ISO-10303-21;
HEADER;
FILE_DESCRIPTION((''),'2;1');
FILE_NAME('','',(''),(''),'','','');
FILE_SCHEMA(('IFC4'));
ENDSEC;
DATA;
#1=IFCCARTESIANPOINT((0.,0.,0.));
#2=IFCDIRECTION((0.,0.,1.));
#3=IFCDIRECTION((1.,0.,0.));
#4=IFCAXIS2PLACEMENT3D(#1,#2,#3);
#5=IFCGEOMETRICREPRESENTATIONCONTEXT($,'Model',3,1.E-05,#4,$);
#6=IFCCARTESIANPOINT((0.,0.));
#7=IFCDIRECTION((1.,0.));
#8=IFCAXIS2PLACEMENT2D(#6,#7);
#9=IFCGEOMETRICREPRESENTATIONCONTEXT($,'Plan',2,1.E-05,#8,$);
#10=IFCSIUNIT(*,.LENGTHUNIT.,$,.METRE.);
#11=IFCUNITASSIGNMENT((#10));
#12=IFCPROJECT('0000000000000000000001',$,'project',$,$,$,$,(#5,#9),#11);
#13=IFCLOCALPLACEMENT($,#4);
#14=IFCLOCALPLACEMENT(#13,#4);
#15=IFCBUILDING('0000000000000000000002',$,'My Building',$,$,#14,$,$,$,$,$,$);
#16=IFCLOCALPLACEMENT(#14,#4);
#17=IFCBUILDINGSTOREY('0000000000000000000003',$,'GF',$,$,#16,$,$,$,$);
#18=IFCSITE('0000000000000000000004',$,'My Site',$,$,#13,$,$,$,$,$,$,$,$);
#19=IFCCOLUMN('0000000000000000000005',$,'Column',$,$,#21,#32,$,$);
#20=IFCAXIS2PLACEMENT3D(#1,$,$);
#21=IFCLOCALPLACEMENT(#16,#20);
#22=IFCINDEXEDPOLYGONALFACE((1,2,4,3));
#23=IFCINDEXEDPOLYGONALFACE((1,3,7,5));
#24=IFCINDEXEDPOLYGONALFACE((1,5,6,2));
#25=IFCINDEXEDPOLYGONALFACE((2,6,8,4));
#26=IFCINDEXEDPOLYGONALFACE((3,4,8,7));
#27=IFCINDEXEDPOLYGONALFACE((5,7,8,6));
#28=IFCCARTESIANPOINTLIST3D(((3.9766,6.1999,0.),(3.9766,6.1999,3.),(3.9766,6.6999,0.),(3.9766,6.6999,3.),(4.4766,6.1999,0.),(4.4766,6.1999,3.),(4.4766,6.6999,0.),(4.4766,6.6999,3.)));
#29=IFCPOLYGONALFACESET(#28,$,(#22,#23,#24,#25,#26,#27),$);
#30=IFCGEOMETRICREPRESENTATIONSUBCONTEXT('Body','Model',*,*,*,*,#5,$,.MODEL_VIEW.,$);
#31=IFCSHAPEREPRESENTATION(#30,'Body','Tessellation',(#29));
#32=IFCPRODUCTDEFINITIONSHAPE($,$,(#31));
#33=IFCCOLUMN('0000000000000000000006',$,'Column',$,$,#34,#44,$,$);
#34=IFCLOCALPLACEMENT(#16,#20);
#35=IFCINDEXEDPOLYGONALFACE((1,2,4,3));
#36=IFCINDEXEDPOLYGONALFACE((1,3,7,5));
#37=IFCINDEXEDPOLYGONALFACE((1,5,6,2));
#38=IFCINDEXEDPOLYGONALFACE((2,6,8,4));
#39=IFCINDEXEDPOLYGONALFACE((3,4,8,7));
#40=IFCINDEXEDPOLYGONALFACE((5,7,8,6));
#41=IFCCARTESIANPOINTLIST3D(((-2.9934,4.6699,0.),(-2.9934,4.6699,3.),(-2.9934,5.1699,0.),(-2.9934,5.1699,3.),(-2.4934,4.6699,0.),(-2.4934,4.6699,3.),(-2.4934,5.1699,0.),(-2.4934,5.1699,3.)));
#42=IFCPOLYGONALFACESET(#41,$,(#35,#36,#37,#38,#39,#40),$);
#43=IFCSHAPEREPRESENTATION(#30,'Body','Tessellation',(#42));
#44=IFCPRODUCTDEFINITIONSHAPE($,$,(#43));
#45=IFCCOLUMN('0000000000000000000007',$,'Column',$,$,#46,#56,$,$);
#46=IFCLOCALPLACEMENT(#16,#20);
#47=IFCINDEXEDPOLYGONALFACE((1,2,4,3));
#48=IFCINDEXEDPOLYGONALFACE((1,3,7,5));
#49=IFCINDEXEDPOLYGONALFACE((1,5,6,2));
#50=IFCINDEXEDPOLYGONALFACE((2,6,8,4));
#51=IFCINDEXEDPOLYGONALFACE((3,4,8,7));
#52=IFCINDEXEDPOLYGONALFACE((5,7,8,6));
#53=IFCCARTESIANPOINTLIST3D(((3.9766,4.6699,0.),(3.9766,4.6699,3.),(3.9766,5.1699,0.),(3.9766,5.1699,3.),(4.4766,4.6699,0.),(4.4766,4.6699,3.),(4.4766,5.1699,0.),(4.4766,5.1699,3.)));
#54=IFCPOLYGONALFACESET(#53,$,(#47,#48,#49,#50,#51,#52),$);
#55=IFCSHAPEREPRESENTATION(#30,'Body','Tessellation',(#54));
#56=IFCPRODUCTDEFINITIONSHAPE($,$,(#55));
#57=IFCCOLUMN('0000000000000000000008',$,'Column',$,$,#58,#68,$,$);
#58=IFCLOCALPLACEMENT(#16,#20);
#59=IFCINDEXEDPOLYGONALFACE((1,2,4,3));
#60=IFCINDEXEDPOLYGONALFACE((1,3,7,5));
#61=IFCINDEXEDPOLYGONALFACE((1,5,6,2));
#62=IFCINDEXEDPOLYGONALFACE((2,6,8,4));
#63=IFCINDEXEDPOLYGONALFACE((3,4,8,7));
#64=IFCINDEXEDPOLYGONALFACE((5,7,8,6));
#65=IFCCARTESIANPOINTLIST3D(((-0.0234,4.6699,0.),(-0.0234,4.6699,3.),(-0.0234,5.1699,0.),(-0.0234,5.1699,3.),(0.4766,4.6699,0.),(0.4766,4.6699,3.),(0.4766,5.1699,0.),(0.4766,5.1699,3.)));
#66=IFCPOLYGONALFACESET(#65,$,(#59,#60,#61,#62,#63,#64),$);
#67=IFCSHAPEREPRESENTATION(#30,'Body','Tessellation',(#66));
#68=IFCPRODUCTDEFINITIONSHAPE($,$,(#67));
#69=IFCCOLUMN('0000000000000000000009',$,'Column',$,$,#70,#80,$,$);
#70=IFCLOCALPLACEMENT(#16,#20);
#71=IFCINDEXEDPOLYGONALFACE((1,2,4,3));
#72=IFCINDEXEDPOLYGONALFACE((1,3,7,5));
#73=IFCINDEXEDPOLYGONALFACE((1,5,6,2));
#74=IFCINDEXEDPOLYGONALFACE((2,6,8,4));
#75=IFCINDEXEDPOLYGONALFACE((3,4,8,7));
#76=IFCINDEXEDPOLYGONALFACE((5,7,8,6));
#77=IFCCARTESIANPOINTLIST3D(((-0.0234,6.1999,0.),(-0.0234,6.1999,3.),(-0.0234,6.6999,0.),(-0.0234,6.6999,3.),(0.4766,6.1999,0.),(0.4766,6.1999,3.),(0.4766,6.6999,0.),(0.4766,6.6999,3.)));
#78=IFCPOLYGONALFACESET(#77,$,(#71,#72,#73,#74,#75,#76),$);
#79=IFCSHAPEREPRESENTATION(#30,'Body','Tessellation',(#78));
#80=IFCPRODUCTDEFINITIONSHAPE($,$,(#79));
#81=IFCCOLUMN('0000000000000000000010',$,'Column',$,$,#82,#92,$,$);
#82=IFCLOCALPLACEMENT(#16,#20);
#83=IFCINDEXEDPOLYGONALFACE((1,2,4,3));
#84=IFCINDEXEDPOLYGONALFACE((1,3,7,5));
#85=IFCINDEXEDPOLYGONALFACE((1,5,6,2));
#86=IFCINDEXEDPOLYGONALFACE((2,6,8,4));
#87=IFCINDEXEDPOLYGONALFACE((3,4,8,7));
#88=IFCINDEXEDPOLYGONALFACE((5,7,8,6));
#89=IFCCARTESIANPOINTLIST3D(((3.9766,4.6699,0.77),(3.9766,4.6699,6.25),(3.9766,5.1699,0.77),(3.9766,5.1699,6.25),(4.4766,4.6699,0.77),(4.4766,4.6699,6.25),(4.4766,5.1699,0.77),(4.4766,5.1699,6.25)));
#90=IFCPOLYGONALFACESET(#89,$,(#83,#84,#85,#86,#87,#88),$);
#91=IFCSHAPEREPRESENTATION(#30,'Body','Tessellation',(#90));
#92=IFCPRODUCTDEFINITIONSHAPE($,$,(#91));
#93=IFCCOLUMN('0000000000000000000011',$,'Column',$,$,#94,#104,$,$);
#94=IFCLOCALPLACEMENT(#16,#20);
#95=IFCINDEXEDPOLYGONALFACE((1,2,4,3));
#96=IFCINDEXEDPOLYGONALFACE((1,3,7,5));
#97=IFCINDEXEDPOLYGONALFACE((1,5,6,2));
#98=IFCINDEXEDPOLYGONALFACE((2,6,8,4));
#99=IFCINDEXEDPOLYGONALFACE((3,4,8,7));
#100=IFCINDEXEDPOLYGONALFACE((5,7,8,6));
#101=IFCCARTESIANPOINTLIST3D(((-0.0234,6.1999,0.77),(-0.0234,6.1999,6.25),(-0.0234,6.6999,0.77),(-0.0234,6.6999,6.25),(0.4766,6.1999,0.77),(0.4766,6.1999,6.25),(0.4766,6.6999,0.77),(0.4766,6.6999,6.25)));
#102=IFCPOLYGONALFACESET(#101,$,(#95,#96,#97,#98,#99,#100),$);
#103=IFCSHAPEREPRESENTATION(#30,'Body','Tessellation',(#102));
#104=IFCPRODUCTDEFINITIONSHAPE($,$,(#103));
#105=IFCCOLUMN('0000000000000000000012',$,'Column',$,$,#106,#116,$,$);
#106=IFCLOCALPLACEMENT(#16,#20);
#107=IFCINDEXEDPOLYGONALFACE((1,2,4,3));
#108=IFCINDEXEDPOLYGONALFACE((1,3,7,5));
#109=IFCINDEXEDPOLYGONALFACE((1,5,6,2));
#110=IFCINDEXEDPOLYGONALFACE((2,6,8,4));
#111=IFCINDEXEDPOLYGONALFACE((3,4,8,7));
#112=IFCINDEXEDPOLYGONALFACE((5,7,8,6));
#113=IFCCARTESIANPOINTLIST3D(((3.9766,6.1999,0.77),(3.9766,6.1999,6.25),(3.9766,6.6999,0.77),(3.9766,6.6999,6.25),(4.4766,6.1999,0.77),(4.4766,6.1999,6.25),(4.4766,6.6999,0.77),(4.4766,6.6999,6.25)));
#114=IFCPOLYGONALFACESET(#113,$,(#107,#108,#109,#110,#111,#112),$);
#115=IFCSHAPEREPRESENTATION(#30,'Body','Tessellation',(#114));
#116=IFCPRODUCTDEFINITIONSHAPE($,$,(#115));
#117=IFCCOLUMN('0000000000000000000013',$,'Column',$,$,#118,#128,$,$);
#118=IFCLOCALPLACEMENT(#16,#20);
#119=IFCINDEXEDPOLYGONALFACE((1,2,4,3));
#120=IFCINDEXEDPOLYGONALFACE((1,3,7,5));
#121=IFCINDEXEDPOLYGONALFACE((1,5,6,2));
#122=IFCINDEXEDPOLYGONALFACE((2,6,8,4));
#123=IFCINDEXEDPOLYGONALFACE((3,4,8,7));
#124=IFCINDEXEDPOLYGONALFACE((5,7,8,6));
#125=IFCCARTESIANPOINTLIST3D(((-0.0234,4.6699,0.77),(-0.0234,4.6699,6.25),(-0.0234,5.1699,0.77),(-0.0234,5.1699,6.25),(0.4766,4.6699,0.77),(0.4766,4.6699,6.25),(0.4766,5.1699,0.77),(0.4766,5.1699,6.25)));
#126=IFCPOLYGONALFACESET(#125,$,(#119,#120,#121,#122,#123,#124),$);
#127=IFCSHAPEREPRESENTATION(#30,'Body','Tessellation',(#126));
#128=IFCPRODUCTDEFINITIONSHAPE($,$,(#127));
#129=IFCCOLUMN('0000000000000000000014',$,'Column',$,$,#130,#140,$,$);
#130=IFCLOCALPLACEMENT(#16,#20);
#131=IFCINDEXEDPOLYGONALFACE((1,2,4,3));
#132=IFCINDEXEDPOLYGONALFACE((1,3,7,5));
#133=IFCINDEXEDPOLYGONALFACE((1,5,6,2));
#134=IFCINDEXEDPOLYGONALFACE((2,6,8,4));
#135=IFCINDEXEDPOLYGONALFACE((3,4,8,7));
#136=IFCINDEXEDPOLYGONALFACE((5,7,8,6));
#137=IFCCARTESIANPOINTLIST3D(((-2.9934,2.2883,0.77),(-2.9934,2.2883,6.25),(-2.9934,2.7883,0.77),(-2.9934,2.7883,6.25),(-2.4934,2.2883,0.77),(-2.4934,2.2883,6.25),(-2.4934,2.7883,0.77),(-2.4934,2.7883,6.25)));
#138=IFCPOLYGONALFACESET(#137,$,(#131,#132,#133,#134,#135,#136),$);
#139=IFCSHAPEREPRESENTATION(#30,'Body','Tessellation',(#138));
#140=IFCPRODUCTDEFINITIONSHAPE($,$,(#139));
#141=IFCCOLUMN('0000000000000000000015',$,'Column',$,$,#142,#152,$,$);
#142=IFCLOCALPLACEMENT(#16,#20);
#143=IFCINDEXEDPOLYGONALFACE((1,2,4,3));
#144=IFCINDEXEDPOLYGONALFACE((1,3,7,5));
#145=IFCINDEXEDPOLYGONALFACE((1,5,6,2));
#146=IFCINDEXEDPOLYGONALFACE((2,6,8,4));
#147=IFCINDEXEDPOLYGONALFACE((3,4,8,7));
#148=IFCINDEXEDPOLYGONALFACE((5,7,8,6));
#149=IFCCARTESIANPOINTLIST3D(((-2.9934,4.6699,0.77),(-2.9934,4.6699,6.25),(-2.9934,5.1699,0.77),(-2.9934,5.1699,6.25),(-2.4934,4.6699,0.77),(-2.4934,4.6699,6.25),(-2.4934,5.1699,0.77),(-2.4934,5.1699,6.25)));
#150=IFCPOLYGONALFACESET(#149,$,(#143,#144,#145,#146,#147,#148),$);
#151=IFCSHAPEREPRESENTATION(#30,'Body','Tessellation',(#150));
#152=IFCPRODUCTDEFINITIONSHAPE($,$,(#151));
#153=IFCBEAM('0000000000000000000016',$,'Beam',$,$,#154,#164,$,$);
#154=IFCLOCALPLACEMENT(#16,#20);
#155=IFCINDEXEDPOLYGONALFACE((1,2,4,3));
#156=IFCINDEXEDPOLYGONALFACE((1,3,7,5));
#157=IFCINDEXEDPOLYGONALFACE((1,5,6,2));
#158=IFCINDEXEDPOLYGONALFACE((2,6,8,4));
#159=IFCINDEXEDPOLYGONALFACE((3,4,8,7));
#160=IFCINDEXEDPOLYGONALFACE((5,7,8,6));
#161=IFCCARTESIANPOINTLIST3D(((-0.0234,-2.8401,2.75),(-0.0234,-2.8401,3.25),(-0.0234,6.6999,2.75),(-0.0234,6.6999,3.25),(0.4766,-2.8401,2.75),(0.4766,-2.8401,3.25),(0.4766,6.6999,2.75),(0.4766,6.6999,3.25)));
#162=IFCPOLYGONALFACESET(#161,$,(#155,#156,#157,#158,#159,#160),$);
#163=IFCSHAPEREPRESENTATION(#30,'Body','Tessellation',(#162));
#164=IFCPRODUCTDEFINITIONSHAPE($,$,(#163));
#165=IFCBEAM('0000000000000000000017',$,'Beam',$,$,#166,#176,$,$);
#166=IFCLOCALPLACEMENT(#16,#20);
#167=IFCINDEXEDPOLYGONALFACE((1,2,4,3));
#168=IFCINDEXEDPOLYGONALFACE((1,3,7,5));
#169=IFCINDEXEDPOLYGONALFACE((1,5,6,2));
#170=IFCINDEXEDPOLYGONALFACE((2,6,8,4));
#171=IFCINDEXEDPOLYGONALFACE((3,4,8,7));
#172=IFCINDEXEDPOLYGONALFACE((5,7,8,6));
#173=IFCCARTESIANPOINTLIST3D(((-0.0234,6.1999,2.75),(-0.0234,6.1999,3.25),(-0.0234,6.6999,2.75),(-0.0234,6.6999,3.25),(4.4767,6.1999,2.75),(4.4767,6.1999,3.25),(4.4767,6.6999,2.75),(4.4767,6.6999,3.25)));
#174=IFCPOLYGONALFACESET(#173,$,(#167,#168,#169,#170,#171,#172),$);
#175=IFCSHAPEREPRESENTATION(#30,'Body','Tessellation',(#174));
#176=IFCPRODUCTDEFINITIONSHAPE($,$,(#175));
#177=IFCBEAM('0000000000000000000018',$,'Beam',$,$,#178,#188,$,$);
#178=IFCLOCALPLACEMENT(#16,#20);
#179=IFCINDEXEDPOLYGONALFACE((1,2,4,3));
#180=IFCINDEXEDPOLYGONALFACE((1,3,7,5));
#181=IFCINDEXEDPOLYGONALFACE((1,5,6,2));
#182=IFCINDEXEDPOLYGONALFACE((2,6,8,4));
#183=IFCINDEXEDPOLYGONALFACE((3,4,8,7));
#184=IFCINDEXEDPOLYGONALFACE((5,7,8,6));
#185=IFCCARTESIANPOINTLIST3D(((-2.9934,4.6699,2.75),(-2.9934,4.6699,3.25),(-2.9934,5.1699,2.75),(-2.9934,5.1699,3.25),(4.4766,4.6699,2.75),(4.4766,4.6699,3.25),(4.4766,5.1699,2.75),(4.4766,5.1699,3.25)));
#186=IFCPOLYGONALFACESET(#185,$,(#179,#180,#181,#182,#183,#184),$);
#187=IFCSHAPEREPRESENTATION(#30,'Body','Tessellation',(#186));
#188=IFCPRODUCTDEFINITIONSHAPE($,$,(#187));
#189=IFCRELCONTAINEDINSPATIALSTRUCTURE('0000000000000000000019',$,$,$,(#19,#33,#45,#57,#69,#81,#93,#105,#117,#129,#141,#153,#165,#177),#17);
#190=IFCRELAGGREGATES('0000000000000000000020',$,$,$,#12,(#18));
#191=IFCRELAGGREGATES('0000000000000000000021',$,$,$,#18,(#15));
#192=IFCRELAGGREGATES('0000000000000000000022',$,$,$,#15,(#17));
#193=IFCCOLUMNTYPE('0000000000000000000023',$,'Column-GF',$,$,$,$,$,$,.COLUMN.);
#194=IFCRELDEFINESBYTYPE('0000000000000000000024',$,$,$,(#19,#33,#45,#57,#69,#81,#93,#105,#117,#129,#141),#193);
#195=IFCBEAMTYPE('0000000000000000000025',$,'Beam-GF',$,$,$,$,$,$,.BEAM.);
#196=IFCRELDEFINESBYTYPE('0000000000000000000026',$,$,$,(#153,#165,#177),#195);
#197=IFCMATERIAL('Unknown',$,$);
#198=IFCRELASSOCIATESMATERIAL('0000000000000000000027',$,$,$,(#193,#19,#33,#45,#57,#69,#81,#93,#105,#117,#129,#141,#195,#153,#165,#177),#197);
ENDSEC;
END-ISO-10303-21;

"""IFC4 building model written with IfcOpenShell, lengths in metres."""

from ifc_helpers import new_model, si_unit, frame, origin_with_axes, origin_2d_with_axis, place, context, subcontext, project, spatial, rectangle, extrude, material, material_profile, profile_set, profile_usage, type_object, element, save


model = new_model("IFC4")

# Units and contexts
model_context = context("Model", 3, precision=1e-05, world=origin_with_axes())
plan_context = context("Plan", 2, precision=1e-05, world=origin_2d_with_axis())
body_context_1 = subcontext(model_context, "Body", "Model", "MODEL_VIEW")
ifc_project = project(units=[si_unit("LENGTHUNIT", "METRE")], contexts=[model_context, plan_context])

# Site, building, storey
site_placement = place(None, origin_with_axes())
site = spatial("IfcSite", under=ifc_project, at=site_placement, Name="My Site")
building_placement = place(site_placement, origin_with_axes())
building = spatial("IfcBuilding", under=site, at=building_placement, Name="My Building")
storey_placement = place(building_placement, origin_with_axes())
storey = spatial("IfcBuildingStorey", under=building, at=storey_placement, Name="GF")

# Columns
ifc_material_1 = material(Name="Unknown")
ifc_material_profile_1 = material_profile(ifc_material_1, rectangle(XDim=0.5, YDim=0.5))
ifc_profile_set_1 = profile_set([ifc_material_profile_1])
ifc_profile_usage_1 = profile_usage(ifc_profile_set_1, cardinal=5)
column_type = type_object("IfcColumnType", Name="Column-GF", PredefinedType="COLUMN", material=ifc_profile_set_1)
column_1_placement = place(storey_placement, frame((4.2266, 6.4499, 0.0), z_axis=(0.0, 0.0, 1.0), x_axis=(1.0, 0.0, 0.0)))
element("IfcColumn", 1, at=column_1_placement, inside=storey, type_object=column_type, material=ifc_profile_usage_1, Name="Column", context=body_context_1, shape_type="SweptSolid", body=[
    extrude(rectangle(XDim=0.5, YDim=0.5), origin_with_axes(), (0.0, 0.0, 1.0), 3.0),
])
ifc_profile_usage_2 = profile_usage(ifc_profile_set_1, cardinal=5)
column_2_placement = place(storey_placement, frame((-2.7434, 4.9199, 0.0), z_axis=(0.0, 0.0, 1.0), x_axis=(1.0, 0.0, 0.0)))
element("IfcColumn", 2, at=column_2_placement, inside=storey, type_object=column_type, material=ifc_profile_usage_2, Name="Column", context=body_context_1, shape_type="SweptSolid", body=[
    extrude(rectangle(XDim=0.5, YDim=0.5), origin_with_axes(), (0.0, 0.0, 1.0), 3.0),
])
ifc_profile_usage_3 = profile_usage(ifc_profile_set_1, cardinal=5)
column_3_placement = place(storey_placement, frame((4.2266, 4.9199, 0.0), z_axis=(0.0, 0.0, 1.0), x_axis=(1.0, 0.0, 0.0)))
element("IfcColumn", 3, at=column_3_placement, inside=storey, type_object=column_type, material=ifc_profile_usage_3, Name="Column", context=body_context_1, shape_type="SweptSolid", body=[
    extrude(rectangle(XDim=0.5, YDim=0.5), origin_with_axes(), (0.0, 0.0, 1.0), 3.0),
])
ifc_profile_usage_4 = profile_usage(ifc_profile_set_1, cardinal=5)
column_4_placement = place(storey_placement, frame((0.2266, 4.9199, 0.0), z_axis=(0.0, 0.0, 1.0), x_axis=(1.0, 0.0, 0.0)))
element("IfcColumn", 4, at=column_4_placement, inside=storey, type_object=column_type, material=ifc_profile_usage_4, Name="Column", context=body_context_1, shape_type="SweptSolid", body=[
    extrude(rectangle(XDim=0.5, YDim=0.5), origin_with_axes(), (0.0, 0.0, 1.0), 3.0),
])
ifc_profile_usage_5 = profile_usage(ifc_profile_set_1, cardinal=5)
column_5_placement = place(storey_placement, frame((0.2266, 6.4499, 0.0), z_axis=(0.0, 0.0, 1.0), x_axis=(1.0, 0.0, 0.0)))
element("IfcColumn", 5, at=column_5_placement, inside=storey, type_object=column_type, material=ifc_profile_usage_5, Name="Column", context=body_context_1, shape_type="SweptSolid", body=[
    extrude(rectangle(XDim=0.5, YDim=0.5), origin_with_axes(), (0.0, 0.0, 1.0), 3.0),
])
ifc_profile_usage_6 = profile_usage(ifc_profile_set_1, cardinal=5)
column_6_placement = place(storey_placement, frame((4.2266, 4.9199, 0.77), z_axis=(0.0, 0.0, 1.0), x_axis=(1.0, 0.0, 0.0)))
element("IfcColumn", 6, at=column_6_placement, inside=storey, type_object=column_type, material=ifc_profile_usage_6, Name="Column", context=body_context_1, shape_type="SweptSolid", body=[
    extrude(rectangle(XDim=0.5, YDim=0.5), origin_with_axes(), (0.0, 0.0, 1.0), 5.48),
])
ifc_profile_usage_7 = profile_usage(ifc_profile_set_1, cardinal=5)
column_7_placement = place(storey_placement, frame((0.2266, 6.4499, 0.77), z_axis=(0.0, 0.0, 1.0), x_axis=(1.0, 0.0, 0.0)))
element("IfcColumn", 7, at=column_7_placement, inside=storey, type_object=column_type, material=ifc_profile_usage_7, Name="Column", context=body_context_1, shape_type="SweptSolid", body=[
    extrude(rectangle(XDim=0.5, YDim=0.5), origin_with_axes(), (0.0, 0.0, 1.0), 5.48),
])
ifc_profile_usage_8 = profile_usage(ifc_profile_set_1, cardinal=5)
column_8_placement = place(storey_placement, frame((4.2266, 6.4499, 0.77), z_axis=(0.0, 0.0, 1.0), x_axis=(1.0, 0.0, 0.0)))
element("IfcColumn", 8, at=column_8_placement, inside=storey, type_object=column_type, material=ifc_profile_usage_8, Name="Column", context=body_context_1, shape_type="SweptSolid", body=[
    extrude(rectangle(XDim=0.5, YDim=0.5), origin_with_axes(), (0.0, 0.0, 1.0), 5.48),
])
ifc_profile_usage_9 = profile_usage(ifc_profile_set_1, cardinal=5)
column_9_placement = place(storey_placement, frame((0.2266, 4.9199, 0.77), z_axis=(0.0, 0.0, 1.0), x_axis=(1.0, 0.0, 0.0)))
element("IfcColumn", 9, at=column_9_placement, inside=storey, type_object=column_type, material=ifc_profile_usage_9, Name="Column", context=body_context_1, shape_type="SweptSolid", body=[
    extrude(rectangle(XDim=0.5, YDim=0.5), origin_with_axes(), (0.0, 0.0, 1.0), 5.48),
])
ifc_profile_usage_10 = profile_usage(ifc_profile_set_1, cardinal=5)
column_10_placement = place(storey_placement, frame((-2.7434, 2.5383, 0.77), z_axis=(0.0, 0.0, 1.0), x_axis=(1.0, 0.0, 0.0)))
element("IfcColumn", 10, at=column_10_placement, inside=storey, type_object=column_type, material=ifc_profile_usage_10, Name="Column", context=body_context_1, shape_type="SweptSolid", body=[
    extrude(rectangle(XDim=0.5, YDim=0.5), origin_with_axes(), (0.0, 0.0, 1.0), 5.48),
])
ifc_profile_usage_11 = profile_usage(ifc_profile_set_1, cardinal=5)
column_11_placement = place(storey_placement, frame((-2.7434, 4.9199, 0.77), z_axis=(0.0, 0.0, 1.0), x_axis=(1.0, 0.0, 0.0)))
element("IfcColumn", 11, at=column_11_placement, inside=storey, type_object=column_type, material=ifc_profile_usage_11, Name="Column", context=body_context_1, shape_type="SweptSolid", body=[
    extrude(rectangle(XDim=0.5, YDim=0.5), origin_with_axes(), (0.0, 0.0, 1.0), 5.48),
])

# Beams
ifc_material_profile_2 = material_profile(ifc_material_1, rectangle(XDim=0.5, YDim=0.5))
ifc_profile_set_2 = profile_set([ifc_material_profile_2])
ifc_profile_usage_12 = profile_usage(ifc_profile_set_2, cardinal=5)
beam_type = type_object("IfcBeamType", Name="Beam-GF", PredefinedType="BEAM", material=ifc_profile_set_2)
beam_1_placement = place(storey_placement, frame((0.2266, 6.6999, 3.0), z_axis=(0.0, -1.0, 0.0), x_axis=(1.0, 0.0, 0.0)))
element("IfcBeam", 12, at=beam_1_placement, inside=storey, type_object=beam_type, material=ifc_profile_usage_12, Name="Beam", context=body_context_1, shape_type="SweptSolid", body=[
    extrude(rectangle(XDim=0.5, YDim=0.5), origin_with_axes(), (0.0, 0.0, 1.0), 9.54),
])
ifc_profile_usage_13 = profile_usage(ifc_profile_set_2, cardinal=5)
beam_2_placement = place(storey_placement, frame((-0.0234, 6.4499, 3.0), z_axis=(1.0, 0.0, 0.0), x_axis=(0.0, 1.0, 0.0)))
element("IfcBeam", 13, at=beam_2_placement, inside=storey, type_object=beam_type, material=ifc_profile_usage_13, Name="Beam", context=body_context_1, shape_type="SweptSolid", body=[
    extrude(rectangle(XDim=0.5, YDim=0.5), origin_with_axes(), (0.0, 0.0, 1.0), 4.5001),
])
ifc_profile_usage_14 = profile_usage(ifc_profile_set_2, cardinal=5)
beam_3_placement = place(storey_placement, frame((4.4766, 4.9199, 3.0), z_axis=(-1.0, -0.000001, 0.000001), x_axis=(0.000001, -1.0, 0.0)))
element("IfcBeam", 14, at=beam_3_placement, inside=storey, type_object=beam_type, material=ifc_profile_usage_14, Name="Beam", context=body_context_1, shape_type="SweptSolid", body=[
    extrude(rectangle(XDim=0.5, YDim=0.5), origin_with_axes(), (0.0, 0.0, 1.0), 7.47),
])

save(model, "model.ifc")
